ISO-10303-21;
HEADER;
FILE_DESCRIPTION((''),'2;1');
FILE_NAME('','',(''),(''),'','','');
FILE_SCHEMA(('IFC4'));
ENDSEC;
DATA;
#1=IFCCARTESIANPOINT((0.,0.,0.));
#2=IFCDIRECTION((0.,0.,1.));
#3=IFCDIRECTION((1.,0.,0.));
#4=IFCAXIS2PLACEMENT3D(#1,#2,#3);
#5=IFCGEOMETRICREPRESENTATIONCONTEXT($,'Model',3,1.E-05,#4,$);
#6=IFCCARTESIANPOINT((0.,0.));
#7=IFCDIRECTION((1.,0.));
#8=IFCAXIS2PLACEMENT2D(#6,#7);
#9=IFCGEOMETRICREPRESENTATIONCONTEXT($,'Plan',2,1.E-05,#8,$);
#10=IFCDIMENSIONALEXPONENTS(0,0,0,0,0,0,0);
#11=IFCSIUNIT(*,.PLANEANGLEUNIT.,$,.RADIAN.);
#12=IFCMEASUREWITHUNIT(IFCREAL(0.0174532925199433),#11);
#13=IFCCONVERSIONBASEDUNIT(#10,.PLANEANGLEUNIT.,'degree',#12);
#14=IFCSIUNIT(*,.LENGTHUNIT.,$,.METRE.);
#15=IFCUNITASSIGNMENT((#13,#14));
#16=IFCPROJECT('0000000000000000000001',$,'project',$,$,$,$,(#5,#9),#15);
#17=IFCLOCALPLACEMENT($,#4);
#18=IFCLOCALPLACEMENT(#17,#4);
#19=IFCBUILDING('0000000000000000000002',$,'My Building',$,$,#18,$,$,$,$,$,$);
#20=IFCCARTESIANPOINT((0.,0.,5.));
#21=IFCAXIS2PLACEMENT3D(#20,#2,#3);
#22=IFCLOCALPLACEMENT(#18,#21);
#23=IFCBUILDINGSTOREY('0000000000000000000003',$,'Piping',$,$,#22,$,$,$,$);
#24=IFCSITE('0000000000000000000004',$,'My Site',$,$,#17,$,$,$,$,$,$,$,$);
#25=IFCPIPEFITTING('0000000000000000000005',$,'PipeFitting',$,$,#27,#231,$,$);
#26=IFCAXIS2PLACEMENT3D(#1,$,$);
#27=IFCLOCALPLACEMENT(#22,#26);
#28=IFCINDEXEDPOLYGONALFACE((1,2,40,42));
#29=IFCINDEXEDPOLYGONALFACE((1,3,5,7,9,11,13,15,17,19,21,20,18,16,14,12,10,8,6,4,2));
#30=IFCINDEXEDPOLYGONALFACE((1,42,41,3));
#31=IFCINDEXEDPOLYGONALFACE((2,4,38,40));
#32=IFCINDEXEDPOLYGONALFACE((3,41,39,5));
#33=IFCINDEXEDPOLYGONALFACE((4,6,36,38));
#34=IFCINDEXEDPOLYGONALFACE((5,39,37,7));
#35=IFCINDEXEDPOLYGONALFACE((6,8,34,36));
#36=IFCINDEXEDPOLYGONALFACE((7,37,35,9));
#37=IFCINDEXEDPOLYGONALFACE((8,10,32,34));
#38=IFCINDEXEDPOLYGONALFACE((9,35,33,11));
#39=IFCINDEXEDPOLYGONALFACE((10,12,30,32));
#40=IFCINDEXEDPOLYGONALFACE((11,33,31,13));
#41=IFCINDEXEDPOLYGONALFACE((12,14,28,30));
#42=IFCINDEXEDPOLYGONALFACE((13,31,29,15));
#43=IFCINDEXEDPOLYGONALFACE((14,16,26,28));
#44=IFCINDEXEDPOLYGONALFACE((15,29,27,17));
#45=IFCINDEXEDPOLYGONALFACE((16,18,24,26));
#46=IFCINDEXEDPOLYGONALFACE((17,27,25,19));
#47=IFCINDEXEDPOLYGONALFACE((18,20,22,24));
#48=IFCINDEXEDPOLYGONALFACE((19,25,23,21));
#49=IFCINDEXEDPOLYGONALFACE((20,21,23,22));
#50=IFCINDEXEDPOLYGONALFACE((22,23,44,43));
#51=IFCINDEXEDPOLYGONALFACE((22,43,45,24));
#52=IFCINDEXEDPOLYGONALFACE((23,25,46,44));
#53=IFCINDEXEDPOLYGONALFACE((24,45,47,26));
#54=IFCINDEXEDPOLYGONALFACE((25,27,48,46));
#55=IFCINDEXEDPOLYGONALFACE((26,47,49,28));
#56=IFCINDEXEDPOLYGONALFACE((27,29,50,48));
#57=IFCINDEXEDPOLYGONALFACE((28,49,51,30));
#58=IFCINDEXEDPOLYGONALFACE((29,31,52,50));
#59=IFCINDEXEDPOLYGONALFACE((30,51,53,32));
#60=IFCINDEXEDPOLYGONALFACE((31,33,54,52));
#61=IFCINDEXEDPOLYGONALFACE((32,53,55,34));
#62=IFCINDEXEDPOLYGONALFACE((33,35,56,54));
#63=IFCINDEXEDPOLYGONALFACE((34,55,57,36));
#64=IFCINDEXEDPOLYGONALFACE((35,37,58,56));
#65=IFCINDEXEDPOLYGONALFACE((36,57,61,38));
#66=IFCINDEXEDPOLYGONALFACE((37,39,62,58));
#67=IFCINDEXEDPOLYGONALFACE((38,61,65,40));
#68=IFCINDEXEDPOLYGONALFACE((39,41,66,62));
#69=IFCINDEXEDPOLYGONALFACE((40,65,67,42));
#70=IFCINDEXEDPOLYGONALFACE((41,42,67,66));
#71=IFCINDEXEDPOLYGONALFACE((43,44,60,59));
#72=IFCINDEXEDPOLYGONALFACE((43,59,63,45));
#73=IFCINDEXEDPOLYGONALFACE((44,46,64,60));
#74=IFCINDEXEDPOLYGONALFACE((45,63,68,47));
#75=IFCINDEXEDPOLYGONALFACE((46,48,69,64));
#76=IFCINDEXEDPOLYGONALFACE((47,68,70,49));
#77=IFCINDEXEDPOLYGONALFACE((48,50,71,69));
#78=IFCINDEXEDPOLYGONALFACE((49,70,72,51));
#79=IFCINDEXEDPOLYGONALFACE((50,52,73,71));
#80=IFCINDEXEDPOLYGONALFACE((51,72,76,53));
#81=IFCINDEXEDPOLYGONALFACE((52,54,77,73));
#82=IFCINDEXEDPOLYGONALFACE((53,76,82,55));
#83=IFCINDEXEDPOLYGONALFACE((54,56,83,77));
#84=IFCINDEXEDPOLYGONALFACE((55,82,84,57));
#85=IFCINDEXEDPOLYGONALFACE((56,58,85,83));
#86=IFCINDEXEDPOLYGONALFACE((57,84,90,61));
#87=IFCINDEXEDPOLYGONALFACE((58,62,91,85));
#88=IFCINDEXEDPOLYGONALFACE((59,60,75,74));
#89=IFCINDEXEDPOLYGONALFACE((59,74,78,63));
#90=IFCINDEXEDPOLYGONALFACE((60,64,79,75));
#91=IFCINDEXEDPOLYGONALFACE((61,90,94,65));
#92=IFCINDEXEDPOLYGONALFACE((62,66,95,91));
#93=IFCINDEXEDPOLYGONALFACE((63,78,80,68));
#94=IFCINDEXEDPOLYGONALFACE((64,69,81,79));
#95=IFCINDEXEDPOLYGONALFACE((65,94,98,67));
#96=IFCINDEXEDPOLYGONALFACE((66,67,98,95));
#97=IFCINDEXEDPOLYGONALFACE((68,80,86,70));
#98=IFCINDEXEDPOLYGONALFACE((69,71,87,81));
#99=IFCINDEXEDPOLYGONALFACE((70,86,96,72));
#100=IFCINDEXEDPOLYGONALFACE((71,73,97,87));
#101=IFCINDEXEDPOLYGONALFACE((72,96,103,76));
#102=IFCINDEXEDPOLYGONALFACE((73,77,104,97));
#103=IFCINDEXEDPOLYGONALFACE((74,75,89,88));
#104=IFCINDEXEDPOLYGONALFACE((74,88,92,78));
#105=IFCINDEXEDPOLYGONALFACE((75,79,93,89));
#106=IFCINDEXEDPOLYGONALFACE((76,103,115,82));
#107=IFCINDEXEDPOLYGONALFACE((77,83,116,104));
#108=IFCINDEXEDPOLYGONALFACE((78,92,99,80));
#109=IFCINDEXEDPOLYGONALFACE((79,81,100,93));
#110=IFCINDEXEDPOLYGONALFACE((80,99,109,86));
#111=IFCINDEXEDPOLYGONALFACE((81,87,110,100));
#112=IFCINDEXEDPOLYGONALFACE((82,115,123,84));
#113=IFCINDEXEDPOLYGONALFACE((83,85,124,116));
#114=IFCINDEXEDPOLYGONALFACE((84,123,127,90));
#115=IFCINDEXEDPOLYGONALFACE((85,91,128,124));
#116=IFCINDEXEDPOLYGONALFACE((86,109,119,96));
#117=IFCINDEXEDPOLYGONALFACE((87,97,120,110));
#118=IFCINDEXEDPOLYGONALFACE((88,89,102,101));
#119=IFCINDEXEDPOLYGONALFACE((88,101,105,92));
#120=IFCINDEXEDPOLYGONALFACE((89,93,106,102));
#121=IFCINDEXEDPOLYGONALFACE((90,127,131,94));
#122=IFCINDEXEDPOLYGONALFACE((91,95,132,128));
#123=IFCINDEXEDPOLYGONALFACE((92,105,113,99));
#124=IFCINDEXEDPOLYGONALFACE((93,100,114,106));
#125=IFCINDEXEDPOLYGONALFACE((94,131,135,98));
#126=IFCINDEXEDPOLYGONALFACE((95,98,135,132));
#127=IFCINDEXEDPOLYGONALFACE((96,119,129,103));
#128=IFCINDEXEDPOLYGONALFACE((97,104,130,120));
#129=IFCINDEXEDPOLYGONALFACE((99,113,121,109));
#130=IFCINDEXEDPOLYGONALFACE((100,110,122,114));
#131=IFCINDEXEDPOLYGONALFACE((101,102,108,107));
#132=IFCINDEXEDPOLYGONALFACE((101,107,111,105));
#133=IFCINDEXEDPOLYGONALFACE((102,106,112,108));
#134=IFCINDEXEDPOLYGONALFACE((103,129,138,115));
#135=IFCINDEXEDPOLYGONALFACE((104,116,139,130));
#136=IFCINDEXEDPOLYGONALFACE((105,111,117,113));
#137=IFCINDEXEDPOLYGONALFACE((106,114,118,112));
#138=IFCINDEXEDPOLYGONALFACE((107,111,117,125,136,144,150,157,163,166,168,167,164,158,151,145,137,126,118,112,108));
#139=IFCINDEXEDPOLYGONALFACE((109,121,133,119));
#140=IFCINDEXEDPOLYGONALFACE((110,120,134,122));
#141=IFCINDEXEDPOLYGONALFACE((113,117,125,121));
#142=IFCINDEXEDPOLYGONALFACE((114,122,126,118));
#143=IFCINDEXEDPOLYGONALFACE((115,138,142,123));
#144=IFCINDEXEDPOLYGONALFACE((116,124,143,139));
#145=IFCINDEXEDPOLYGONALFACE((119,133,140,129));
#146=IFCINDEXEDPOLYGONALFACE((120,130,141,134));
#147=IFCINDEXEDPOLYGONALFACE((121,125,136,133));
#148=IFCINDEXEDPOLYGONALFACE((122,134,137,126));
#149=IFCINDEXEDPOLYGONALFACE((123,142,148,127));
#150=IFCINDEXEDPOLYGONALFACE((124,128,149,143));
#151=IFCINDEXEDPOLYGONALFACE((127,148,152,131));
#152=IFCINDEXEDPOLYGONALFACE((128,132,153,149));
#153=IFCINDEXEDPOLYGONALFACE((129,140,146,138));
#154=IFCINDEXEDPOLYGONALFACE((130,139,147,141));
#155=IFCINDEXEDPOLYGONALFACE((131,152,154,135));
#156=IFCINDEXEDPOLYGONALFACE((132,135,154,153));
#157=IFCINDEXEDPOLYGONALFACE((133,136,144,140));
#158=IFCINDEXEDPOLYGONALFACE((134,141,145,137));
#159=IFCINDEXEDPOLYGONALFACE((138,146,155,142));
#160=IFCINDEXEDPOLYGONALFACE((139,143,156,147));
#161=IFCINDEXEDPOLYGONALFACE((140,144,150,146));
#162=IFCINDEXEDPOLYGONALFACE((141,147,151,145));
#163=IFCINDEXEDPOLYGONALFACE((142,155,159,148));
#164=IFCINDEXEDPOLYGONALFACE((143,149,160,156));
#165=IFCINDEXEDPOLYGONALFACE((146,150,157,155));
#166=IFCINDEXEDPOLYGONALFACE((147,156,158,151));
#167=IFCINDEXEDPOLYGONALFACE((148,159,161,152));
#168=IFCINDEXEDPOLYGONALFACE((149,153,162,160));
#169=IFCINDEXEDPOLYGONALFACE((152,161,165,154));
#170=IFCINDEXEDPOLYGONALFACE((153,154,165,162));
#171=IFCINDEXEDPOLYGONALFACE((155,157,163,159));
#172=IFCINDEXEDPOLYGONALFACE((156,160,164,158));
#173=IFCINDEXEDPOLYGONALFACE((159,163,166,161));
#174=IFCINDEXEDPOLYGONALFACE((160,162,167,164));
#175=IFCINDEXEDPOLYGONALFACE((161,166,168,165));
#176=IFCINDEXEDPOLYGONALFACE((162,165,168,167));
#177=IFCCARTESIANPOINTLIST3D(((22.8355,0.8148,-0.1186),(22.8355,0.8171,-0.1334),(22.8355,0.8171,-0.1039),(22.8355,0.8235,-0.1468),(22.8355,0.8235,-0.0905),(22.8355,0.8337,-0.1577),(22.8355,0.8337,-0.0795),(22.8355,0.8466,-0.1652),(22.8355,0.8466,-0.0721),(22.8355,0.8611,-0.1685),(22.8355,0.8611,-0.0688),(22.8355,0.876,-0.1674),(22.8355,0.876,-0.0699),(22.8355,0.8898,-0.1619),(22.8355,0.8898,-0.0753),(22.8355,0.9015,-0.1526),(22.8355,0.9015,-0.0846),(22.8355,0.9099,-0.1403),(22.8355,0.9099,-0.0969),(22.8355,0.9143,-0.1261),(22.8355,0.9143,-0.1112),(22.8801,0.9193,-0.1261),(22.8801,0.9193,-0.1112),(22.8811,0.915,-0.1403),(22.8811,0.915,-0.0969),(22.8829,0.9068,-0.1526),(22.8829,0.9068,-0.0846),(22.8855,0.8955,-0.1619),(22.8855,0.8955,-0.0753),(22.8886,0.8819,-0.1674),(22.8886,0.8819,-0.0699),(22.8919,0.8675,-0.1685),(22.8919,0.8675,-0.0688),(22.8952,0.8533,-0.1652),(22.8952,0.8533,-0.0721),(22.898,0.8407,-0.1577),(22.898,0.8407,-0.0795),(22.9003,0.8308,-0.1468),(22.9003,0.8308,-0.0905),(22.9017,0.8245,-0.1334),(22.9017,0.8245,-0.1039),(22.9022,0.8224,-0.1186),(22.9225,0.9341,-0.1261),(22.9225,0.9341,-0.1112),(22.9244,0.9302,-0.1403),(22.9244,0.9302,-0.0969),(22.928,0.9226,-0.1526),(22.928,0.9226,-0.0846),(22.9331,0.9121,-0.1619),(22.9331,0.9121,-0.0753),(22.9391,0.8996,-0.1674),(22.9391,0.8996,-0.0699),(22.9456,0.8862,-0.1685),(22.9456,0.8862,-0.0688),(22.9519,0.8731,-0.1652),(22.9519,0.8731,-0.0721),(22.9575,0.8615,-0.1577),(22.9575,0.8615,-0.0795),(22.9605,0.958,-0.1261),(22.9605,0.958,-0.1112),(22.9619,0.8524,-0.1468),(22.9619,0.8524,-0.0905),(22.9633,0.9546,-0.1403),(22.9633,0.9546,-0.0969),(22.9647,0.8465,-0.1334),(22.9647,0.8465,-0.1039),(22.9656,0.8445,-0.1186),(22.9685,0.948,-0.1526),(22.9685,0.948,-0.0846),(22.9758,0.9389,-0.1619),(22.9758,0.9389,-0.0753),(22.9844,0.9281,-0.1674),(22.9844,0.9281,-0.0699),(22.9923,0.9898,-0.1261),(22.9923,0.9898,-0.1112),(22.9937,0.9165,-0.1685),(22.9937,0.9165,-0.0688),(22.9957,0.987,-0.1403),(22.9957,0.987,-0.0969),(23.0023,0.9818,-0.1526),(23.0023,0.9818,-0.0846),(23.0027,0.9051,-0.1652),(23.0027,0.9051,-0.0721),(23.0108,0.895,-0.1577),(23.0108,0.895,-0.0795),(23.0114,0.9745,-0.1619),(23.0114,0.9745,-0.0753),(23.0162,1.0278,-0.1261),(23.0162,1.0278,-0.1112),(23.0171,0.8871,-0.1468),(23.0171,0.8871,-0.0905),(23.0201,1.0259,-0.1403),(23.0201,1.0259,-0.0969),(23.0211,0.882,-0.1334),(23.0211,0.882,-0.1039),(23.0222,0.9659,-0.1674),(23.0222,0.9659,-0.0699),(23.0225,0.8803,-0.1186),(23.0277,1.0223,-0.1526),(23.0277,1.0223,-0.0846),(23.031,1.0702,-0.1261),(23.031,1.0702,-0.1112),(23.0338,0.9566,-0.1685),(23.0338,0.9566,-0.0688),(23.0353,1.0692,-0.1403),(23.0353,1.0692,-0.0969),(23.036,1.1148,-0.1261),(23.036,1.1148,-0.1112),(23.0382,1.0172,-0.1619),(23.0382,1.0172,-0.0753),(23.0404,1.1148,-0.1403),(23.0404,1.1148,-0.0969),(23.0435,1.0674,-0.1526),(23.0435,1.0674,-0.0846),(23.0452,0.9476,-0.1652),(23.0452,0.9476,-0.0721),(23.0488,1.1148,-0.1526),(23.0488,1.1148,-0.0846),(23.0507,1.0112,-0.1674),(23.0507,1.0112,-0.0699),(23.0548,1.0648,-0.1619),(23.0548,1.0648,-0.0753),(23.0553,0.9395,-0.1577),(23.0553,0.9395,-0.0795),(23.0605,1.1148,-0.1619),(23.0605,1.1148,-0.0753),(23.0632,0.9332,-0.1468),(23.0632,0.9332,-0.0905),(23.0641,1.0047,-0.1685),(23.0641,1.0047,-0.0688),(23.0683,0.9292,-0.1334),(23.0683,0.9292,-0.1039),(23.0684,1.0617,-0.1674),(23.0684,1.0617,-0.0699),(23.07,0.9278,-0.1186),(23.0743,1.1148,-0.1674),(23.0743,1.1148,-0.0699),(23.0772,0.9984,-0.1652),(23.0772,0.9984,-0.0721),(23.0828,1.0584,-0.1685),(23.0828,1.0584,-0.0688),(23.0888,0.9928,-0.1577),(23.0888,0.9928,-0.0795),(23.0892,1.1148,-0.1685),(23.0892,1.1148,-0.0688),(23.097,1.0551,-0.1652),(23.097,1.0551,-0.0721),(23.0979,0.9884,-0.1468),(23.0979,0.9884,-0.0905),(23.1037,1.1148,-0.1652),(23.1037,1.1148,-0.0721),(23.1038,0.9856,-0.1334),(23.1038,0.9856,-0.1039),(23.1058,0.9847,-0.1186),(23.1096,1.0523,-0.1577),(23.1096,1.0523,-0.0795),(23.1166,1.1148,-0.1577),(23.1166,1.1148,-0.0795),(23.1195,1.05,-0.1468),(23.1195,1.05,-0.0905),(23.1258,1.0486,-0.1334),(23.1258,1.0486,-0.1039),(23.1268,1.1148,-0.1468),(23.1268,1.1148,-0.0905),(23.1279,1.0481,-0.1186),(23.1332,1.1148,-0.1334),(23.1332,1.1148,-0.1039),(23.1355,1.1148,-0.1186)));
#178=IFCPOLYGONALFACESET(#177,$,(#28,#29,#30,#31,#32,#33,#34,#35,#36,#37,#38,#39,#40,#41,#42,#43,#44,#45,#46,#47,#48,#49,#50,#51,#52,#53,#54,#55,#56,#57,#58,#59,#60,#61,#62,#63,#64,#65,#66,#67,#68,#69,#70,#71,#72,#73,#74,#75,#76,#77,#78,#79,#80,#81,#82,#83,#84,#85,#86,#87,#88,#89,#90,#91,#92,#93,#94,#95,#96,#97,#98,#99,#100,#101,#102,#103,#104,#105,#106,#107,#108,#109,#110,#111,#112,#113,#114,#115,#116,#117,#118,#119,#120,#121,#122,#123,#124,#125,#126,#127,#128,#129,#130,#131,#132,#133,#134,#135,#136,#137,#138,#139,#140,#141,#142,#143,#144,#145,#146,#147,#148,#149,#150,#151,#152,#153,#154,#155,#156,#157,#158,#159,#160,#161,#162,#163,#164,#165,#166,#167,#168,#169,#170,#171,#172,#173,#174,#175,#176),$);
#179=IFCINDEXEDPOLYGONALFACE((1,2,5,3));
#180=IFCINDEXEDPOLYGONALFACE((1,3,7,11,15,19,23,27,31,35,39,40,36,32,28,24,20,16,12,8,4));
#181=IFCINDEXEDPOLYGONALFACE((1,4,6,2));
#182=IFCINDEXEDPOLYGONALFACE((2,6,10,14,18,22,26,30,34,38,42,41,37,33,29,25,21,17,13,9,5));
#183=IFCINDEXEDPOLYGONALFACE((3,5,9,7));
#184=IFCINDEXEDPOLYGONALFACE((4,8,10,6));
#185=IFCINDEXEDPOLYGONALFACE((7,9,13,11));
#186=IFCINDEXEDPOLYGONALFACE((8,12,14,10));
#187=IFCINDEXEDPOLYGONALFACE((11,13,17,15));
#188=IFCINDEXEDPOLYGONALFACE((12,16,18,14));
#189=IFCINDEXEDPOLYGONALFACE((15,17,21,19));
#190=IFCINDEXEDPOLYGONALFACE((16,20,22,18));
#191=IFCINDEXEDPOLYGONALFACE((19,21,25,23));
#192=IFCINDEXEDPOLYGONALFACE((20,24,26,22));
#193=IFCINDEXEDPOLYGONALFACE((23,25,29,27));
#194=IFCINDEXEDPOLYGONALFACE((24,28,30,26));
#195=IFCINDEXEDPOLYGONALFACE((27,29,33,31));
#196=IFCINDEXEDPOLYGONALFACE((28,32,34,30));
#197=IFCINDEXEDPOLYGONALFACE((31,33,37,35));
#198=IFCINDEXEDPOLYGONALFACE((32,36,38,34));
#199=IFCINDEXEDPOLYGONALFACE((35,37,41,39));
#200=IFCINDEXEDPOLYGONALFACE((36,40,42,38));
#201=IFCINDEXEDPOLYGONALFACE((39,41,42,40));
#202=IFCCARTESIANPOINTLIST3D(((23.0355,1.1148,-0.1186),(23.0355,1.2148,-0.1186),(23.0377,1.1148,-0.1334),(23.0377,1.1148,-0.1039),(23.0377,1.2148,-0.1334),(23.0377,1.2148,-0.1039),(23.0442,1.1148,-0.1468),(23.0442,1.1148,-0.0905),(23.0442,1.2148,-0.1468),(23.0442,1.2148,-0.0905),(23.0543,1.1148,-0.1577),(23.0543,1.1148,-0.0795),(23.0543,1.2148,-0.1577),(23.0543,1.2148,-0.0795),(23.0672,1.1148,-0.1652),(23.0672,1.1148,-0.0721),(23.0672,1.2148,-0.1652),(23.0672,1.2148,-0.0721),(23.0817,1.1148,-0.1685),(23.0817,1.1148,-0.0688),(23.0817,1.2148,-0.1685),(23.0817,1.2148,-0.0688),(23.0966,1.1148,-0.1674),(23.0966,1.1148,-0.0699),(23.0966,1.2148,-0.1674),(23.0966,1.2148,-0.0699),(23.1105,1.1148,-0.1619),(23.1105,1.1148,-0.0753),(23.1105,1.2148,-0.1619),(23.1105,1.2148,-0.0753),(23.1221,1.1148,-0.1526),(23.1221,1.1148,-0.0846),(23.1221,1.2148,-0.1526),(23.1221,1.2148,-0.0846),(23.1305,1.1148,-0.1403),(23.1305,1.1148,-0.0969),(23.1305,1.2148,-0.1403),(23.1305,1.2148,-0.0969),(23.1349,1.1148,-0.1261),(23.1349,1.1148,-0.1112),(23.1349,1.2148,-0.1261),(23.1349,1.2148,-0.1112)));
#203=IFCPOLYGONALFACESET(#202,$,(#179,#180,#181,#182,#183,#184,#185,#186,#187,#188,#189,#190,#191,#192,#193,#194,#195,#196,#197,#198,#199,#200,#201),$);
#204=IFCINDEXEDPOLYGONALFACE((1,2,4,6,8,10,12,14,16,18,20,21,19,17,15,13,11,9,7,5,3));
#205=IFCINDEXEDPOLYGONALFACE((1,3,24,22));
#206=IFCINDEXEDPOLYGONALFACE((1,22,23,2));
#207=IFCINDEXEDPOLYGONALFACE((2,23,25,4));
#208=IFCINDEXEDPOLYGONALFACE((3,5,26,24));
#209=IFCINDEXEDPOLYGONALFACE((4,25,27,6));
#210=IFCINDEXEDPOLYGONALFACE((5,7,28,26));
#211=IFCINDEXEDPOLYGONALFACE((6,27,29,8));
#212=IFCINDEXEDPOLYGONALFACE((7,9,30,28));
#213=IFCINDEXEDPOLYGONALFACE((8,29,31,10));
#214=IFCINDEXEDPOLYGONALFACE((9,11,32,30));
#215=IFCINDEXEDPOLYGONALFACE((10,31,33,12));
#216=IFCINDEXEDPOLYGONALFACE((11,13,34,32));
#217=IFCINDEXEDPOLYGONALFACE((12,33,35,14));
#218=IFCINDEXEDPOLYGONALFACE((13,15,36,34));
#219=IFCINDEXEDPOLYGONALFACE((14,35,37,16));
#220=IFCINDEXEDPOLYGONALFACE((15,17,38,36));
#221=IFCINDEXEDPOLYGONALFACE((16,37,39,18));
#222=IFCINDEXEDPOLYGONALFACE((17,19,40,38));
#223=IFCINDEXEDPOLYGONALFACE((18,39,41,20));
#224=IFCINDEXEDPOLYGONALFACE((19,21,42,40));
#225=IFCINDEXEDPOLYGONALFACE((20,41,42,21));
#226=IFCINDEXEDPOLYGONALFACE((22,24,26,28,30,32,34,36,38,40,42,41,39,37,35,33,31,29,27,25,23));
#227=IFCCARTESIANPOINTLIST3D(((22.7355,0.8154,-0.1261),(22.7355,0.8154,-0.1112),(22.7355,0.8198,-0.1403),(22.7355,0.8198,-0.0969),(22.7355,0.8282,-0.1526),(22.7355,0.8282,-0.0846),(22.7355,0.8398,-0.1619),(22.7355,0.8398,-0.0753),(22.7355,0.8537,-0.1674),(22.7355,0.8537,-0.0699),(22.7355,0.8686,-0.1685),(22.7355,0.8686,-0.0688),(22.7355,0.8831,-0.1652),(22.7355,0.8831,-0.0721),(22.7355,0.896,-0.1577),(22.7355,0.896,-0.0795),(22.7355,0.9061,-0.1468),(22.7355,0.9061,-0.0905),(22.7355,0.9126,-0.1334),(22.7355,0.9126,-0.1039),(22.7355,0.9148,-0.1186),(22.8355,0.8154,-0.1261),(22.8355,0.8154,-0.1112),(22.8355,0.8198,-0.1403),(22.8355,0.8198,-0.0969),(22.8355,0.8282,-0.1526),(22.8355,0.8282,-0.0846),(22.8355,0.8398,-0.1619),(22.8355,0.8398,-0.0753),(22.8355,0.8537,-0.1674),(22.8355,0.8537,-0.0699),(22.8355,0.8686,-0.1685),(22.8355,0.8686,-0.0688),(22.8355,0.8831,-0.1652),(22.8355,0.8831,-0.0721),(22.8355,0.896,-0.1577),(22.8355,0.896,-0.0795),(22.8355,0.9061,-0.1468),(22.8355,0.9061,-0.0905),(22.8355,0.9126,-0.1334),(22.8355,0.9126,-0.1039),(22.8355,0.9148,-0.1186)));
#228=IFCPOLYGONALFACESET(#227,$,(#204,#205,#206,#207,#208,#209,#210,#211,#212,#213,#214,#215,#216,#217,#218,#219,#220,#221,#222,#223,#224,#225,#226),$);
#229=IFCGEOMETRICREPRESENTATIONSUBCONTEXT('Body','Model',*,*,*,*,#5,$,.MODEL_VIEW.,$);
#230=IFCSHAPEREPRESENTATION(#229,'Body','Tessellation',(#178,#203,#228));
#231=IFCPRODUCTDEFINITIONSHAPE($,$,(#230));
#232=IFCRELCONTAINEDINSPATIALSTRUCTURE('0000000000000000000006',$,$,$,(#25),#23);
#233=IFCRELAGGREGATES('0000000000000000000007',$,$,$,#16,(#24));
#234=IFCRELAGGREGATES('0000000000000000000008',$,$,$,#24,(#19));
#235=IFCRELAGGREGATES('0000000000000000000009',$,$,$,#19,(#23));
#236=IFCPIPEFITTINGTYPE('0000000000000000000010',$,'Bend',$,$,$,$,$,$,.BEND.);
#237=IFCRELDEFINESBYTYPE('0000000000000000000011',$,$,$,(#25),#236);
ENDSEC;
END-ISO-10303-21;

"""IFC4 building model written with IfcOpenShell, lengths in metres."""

from ifc_helpers import new_model, entity, si_unit, converted_unit, frame, origin_with_axes, origin_2d_with_axis, place, context, subcontext, project, spatial, circle, extrude, source, transform, mapped, type_object, type_shapes, element, save


model = new_model("IFC4")

# Units and contexts
model_context = context("Model", 3, precision=1e-05, world=origin_with_axes())
plan_context = context("Plan", 2, precision=1e-05, world=origin_2d_with_axis())
body_context = subcontext(model_context, "Body", "Model", "MODEL_VIEW")
ifc_project = project(units=[converted_unit("PLANEANGLEUNIT", "degree", entity("IfcReal", 0.0174532925199433), si_unit("PLANEANGLEUNIT", "RADIAN"), dimensions=[0, 0, 0, 0, 0, 0, 0]), si_unit("LENGTHUNIT", "METRE")], contexts=[model_context, plan_context])

# Site, building, storey
site_placement = place(None, origin_with_axes())
site = spatial("IfcSite", under=ifc_project, at=site_placement, Name="My Site")
building_placement = place(site_placement, origin_with_axes())
building = spatial("IfcBuilding", under=site, at=building_placement, Name="My Building")
storey_placement = place(building_placement, frame((0.0, 0.0, 5.0), z_axis=(0.0, 0.0, 1.0), x_axis=(1.0, 0.0, 0.0)))
storey = spatial("IfcBuildingStorey", under=building, at=storey_placement, Name="Piping")

# Pipe fitting
pipe_fitting_type_1 = type_object("IfcPipeFittingType", Name="Bend", PredefinedType="BEND")
shared_shape = source(origin_with_axes(), body_context, "Body", "SolidModel", [
    entity("IfcSweptDiskSolid", entity("IfcIndexedPolyCurve", entity("IfcCartesianPointList3D", [[0.0, 0.0, -0.1], [0.0732, 0.0, -0.2768], [0.25, 0.0, -0.35]]), [entity("IfcArcIndex", [1, 2, 3])]), 0.05),
    extrude(circle(Radius=0.05), origin_with_axes(), (0.0, 0.0, -1.0), 0.1),
    extrude(circle(Radius=0.05), frame((0.25, 0.0, -0.35), z_axis=(1.0, 0.0, 0.0), x_axis=(0.0, 0.0, 1.0)), (0.0, 0.0, 1.0), 0.1),
])
type_shapes(pipe_fitting_type_1, [shared_shape])
for number, where, z_axis, x_axis, name in (
    (1, (23.0855, 1.2148, -0.1186), (0.0, 1.0, 0.000001), (-1.0, 0.0, 0.0), "PipeFitting"),
):
    element("IfcPipeFitting", number, at=place(storey_placement, frame(where, z_axis=z_axis, x_axis=x_axis)), inside=storey, type_object=pipe_fitting_type_1, Name=name, context=body_context, shape_type="MappedRepresentation", body=[
        mapped(shared_shape, transform((0.0, 0.0, 0.0), x_axis=(1.0, 0.0, 0.0), y_axis=(0.0, 1.0, 0.0), z_axis=(0.0, 0.0, 1.0), scale=1.0)),
    ])

save(model, "model.ifc")
